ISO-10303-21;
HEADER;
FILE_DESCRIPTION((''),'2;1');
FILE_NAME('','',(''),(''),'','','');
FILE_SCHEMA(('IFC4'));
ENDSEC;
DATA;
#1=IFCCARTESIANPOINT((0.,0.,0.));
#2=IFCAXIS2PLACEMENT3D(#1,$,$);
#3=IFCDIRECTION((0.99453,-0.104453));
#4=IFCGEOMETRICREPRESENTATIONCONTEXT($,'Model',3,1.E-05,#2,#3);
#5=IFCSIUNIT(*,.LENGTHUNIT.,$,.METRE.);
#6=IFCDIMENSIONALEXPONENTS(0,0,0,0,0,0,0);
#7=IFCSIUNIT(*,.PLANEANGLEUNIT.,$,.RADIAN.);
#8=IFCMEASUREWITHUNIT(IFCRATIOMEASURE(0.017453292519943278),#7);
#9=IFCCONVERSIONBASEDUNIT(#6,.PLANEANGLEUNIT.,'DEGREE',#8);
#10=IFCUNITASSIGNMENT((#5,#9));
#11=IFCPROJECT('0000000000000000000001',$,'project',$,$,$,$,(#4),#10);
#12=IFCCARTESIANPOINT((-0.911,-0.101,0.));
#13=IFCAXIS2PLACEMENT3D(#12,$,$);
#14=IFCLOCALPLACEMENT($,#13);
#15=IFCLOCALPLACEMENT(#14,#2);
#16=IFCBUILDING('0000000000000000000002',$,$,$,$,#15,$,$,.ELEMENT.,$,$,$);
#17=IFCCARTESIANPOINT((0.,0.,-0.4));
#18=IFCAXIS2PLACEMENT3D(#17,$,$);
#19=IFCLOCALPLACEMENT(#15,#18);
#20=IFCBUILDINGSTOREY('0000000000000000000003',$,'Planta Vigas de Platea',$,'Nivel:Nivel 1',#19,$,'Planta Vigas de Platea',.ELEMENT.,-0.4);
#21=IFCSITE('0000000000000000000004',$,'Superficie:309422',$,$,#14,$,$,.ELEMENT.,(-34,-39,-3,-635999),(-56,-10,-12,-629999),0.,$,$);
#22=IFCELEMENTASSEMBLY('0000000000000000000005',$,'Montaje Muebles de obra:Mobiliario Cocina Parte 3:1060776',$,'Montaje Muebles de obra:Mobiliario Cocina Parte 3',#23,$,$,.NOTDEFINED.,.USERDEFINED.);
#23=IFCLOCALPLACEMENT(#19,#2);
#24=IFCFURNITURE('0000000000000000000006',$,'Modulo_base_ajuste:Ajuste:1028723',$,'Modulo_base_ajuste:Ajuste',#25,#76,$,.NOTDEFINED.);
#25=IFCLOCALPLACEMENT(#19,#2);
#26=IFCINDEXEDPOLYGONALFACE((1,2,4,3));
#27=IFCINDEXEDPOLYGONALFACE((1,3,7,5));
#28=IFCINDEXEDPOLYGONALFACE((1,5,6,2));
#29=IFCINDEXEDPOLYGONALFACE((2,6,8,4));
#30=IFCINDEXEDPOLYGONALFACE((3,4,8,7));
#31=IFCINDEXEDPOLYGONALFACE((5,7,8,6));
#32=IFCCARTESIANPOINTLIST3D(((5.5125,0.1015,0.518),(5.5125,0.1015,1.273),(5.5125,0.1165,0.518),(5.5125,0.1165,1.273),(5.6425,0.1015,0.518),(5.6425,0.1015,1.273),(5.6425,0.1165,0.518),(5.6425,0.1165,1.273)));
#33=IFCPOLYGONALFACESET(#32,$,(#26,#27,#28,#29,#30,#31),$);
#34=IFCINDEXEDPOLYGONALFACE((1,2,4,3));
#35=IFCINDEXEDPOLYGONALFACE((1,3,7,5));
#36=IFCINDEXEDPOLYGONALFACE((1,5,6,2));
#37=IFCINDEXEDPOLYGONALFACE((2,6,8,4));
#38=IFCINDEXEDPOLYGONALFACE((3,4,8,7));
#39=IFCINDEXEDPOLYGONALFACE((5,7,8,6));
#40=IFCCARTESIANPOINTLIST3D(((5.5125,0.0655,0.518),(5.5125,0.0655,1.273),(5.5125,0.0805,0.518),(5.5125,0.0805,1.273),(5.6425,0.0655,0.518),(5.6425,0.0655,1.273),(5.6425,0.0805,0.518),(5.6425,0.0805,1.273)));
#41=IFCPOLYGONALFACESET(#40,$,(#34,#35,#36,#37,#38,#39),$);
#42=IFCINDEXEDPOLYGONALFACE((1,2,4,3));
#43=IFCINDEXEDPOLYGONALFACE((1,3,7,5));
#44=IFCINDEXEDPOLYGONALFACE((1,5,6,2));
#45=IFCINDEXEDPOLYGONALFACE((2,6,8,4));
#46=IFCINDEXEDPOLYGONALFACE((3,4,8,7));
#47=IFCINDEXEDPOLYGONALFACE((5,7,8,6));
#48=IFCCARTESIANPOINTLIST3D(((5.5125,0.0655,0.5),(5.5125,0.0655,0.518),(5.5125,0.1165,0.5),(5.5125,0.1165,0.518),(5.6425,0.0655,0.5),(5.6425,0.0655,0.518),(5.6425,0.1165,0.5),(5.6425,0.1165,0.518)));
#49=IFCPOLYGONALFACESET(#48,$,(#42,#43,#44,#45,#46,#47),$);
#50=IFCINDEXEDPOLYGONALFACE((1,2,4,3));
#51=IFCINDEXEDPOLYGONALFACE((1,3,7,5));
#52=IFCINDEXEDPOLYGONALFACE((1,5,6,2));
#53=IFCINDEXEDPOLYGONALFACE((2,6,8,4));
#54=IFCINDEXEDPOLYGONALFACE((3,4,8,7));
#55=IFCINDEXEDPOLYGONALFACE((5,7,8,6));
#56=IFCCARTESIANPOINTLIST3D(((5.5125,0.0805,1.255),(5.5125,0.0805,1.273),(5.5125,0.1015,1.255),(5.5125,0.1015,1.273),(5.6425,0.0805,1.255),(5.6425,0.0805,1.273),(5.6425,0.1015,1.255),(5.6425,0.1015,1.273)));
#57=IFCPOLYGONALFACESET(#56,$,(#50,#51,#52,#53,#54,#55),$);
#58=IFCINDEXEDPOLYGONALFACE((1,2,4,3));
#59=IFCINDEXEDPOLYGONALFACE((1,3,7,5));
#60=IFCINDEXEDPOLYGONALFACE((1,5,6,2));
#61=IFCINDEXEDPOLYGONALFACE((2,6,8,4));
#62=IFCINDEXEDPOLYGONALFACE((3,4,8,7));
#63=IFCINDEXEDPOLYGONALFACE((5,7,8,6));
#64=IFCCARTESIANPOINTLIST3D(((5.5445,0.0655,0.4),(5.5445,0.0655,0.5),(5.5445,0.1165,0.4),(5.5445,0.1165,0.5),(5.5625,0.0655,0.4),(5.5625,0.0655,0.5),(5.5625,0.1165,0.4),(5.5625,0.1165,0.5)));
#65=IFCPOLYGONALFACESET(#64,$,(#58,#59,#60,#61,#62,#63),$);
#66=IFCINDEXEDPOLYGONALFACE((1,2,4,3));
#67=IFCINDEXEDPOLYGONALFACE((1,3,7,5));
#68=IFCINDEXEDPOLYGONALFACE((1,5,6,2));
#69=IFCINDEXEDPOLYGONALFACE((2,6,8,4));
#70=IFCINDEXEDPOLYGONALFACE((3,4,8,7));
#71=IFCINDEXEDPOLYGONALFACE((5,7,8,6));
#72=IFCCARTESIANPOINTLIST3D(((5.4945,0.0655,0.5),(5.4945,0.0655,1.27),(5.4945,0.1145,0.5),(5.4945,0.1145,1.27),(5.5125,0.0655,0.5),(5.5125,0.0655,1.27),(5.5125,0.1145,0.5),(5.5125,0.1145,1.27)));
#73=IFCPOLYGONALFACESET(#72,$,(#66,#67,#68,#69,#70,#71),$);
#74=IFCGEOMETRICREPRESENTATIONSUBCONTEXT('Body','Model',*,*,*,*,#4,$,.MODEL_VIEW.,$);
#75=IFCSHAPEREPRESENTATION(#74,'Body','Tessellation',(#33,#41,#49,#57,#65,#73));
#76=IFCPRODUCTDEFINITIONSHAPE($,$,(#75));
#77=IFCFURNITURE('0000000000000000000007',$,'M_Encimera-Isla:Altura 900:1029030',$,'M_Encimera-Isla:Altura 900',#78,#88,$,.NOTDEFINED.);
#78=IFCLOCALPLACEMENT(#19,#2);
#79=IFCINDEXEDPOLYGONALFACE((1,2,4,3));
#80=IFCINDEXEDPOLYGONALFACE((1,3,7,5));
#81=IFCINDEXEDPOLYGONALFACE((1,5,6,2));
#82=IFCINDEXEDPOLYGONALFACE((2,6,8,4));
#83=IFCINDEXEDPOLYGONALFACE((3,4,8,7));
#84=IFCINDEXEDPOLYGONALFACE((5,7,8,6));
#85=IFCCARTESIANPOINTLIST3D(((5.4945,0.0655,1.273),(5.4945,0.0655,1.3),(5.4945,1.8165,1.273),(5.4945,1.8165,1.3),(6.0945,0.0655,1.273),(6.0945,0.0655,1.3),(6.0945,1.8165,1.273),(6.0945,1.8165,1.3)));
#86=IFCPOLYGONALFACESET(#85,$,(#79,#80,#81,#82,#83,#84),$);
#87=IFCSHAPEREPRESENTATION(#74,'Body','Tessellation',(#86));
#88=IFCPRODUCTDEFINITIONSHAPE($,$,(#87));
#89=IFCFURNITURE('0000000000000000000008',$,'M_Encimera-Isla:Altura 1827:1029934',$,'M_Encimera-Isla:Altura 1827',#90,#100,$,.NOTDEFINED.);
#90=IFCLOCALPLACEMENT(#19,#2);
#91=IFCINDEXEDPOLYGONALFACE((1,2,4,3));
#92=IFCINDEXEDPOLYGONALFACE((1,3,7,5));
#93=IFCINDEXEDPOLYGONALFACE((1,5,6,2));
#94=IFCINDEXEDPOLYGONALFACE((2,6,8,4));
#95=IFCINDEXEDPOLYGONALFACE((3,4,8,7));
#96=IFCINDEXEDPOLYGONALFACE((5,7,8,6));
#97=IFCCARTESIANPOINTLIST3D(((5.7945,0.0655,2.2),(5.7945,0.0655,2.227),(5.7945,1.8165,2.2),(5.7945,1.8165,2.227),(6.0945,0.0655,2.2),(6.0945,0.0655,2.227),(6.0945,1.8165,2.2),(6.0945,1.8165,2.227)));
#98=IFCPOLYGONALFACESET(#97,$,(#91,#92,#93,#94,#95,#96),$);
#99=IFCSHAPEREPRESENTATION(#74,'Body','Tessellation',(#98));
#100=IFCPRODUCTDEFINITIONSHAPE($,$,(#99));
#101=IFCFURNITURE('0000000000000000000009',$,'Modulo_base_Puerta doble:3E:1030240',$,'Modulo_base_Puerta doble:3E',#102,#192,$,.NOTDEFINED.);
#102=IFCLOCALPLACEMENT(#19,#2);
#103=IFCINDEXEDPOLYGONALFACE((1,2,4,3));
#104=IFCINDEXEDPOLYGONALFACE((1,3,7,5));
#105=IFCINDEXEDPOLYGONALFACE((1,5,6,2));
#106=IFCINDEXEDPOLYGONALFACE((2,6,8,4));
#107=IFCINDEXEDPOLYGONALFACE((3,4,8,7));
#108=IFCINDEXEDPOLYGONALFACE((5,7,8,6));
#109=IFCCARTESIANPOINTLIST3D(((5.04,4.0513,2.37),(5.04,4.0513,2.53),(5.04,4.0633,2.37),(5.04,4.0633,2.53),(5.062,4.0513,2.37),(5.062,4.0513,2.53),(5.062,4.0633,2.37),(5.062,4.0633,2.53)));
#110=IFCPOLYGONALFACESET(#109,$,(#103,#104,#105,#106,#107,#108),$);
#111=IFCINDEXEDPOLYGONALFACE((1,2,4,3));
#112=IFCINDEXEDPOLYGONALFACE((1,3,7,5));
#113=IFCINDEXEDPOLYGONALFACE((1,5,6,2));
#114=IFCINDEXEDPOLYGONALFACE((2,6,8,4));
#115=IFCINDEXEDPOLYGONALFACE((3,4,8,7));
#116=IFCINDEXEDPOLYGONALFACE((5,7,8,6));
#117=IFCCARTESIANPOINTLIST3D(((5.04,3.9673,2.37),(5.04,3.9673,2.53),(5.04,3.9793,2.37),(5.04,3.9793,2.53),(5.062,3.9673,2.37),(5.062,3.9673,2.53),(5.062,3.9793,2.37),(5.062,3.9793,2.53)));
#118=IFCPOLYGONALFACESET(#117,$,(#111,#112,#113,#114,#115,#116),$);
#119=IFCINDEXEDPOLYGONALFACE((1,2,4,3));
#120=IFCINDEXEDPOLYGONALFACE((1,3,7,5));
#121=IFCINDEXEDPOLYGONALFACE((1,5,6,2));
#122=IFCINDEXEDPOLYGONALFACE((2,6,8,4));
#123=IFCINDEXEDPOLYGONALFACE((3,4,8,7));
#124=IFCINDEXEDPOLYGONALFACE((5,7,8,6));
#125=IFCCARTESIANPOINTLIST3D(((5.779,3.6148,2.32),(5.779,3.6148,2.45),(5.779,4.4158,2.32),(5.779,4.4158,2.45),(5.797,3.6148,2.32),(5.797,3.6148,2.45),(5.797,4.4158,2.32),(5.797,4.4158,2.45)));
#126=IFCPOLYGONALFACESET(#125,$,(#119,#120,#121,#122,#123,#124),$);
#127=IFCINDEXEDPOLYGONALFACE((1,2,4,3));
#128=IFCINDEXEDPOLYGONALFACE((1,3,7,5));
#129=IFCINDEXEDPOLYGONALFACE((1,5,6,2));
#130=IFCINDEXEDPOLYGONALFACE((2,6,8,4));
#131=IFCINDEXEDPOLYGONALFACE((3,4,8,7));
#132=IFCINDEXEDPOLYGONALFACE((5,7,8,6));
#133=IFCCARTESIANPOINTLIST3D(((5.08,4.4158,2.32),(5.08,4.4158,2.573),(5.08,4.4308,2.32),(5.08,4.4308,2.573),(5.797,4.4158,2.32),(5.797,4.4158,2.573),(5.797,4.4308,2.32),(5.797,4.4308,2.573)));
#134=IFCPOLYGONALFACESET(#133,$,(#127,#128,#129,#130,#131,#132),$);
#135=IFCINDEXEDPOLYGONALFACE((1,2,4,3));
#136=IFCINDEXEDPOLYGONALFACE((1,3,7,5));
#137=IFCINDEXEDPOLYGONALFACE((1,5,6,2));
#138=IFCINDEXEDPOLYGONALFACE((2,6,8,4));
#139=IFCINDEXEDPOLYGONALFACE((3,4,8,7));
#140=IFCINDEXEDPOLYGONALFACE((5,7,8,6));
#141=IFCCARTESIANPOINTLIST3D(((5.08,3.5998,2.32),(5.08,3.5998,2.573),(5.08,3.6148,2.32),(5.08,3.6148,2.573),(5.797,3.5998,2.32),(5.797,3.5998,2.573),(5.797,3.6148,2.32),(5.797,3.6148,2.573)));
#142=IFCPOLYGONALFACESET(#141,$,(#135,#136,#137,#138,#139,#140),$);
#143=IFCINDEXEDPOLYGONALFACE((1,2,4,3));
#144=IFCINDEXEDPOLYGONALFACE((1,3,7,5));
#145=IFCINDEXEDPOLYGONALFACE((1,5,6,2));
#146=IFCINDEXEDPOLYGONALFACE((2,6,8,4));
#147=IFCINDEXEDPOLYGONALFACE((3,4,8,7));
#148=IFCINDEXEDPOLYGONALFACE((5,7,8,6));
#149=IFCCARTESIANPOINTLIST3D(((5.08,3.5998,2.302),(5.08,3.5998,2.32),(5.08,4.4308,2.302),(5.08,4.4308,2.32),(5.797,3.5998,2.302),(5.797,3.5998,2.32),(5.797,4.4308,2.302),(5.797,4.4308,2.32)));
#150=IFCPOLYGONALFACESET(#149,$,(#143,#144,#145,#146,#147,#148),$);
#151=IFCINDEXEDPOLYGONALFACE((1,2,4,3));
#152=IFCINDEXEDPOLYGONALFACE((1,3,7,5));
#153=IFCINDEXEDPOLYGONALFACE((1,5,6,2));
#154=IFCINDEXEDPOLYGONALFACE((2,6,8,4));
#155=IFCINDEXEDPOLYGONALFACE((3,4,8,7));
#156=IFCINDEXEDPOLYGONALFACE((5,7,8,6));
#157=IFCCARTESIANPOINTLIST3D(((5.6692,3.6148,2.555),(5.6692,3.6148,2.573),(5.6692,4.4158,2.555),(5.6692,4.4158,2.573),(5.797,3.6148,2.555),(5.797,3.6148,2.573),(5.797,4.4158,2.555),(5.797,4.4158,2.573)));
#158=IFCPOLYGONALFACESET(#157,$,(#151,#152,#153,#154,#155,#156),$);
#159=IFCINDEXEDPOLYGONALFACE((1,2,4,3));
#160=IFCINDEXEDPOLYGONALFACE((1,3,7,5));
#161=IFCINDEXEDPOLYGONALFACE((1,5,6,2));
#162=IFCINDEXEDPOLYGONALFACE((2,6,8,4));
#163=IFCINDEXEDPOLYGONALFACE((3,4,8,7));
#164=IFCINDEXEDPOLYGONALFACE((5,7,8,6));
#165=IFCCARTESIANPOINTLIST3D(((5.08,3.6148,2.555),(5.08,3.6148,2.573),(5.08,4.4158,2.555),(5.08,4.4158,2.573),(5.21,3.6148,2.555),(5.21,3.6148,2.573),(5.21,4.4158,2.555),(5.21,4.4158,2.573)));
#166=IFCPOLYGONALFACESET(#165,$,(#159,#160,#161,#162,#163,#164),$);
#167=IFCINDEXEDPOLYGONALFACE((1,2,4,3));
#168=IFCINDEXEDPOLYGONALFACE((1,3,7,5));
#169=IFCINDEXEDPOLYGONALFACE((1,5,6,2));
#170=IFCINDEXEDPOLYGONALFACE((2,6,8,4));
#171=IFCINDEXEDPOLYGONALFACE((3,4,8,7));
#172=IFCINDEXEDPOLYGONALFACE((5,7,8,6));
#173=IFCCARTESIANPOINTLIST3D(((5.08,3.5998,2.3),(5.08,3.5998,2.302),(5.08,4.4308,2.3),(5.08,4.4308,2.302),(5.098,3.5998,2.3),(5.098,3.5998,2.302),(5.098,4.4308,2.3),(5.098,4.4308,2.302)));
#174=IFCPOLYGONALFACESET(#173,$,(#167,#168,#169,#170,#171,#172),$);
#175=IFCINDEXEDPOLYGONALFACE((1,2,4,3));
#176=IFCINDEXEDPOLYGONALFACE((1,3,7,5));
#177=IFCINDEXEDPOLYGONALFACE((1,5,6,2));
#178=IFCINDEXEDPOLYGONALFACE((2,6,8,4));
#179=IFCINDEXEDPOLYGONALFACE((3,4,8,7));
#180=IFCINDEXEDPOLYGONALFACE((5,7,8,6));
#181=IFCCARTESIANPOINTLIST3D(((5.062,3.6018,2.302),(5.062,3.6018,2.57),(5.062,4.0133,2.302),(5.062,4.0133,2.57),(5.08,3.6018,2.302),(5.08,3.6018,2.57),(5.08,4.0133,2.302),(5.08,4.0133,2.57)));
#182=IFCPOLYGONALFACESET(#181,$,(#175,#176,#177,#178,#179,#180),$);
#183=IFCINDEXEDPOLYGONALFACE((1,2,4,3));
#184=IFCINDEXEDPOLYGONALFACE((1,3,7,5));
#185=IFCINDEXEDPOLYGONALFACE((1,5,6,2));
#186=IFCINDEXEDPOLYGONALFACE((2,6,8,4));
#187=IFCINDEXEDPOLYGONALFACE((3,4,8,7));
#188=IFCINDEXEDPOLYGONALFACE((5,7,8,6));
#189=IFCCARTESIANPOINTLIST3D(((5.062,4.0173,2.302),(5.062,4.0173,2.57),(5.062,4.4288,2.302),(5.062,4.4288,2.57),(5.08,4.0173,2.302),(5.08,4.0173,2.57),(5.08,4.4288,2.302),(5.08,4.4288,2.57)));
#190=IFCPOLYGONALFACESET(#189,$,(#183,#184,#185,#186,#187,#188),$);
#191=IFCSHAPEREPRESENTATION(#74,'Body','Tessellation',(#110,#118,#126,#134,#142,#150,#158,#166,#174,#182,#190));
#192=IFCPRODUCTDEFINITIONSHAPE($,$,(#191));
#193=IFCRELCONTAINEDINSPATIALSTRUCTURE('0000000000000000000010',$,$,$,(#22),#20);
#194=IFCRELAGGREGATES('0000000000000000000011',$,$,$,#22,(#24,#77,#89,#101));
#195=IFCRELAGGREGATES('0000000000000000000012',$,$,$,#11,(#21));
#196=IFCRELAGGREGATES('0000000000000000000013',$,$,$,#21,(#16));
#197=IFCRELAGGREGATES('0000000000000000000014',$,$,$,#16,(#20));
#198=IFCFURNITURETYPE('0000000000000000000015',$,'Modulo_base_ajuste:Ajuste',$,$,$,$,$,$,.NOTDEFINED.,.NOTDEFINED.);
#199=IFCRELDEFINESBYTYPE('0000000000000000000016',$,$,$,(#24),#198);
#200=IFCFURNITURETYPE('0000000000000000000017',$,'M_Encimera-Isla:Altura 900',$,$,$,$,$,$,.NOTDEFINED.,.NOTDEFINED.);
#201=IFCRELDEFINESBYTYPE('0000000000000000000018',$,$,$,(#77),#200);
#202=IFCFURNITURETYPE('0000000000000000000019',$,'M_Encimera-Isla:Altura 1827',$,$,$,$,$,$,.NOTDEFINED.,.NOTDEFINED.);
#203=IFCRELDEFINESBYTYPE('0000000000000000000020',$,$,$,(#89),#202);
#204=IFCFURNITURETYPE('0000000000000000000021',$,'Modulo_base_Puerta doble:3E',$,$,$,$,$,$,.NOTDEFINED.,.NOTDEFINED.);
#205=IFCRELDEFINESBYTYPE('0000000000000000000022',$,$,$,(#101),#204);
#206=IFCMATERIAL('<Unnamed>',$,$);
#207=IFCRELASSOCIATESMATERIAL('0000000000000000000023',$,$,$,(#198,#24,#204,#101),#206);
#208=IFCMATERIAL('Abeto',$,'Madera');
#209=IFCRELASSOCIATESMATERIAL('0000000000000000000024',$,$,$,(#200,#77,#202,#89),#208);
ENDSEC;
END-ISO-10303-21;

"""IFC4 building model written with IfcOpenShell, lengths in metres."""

from ifc_helpers import new_model, entity, si_unit, converted_unit, direction, frame, frame_2d, origin, origin_2d_with_axis, place, context, subcontext, project, spatial, rectangle, extrude, source, transform, mapped, material, type_object, type_shapes, element, aggregate, save


model = new_model("IFC4")

# Units and contexts
model_context = context("Model", 3, precision=1e-05, world=origin(), true_north=direction((0.99453, -0.104453)))
body_context = subcontext(model_context, "Body", "Model", "MODEL_VIEW")
ifc_project = project(units=[si_unit("LENGTHUNIT", "METRE"), converted_unit("PLANEANGLEUNIT", "DEGREE", entity("IfcRatioMeasure", 0.017453292519943278), si_unit("PLANEANGLEUNIT", "RADIAN"), dimensions=[0, 0, 0, 0, 0, 0, 0])], contexts=[model_context])

# Site, building, storey
site_placement = place(None, frame((-0.911, -0.101, 0.0)))
site = spatial("IfcSite", under=ifc_project, at=site_placement, Name="Superficie:309422", CompositionType="ELEMENT", RefLatitude=(-34, -39, -3, -635999), RefLongitude=(-56, -10, -12, -629999), RefElevation=0.0)
building_placement = place(site_placement, origin())
building = spatial("IfcBuilding", under=site, at=building_placement, CompositionType="ELEMENT")
storey_placement = place(building_placement, frame((0.0, 0.0, -0.4)))
storey = spatial("IfcBuildingStorey", under=building, at=storey_placement, Name="Planta Vigas de Platea", ObjectType="Nivel:Nivel 1", LongName="Planta Vigas de Platea", CompositionType="ELEMENT", Elevation=-0.4)

# Element assembly, furniture
ifc_material_1 = material(Name="Abeto", Category="Madera")
ifc_material_2 = material(Name="<Unnamed>")
assembly_1_placement = place(storey_placement, origin())
assembly_1 = element("IfcElementAssembly", 1, at=assembly_1_placement, inside=storey, Name="Montaje Muebles de obra:Mobiliario Cocina Parte 3:1060776", ObjectType="Montaje Muebles de obra:Mobiliario Cocina Parte 3", AssemblyPlace="NOTDEFINED", PredefinedType="USERDEFINED")
furniture_type_1 = type_object("IfcFurnitureType", Name="Modulo_base_ajuste:Ajuste", AssemblyPlace="NOTDEFINED", PredefinedType="NOTDEFINED", material=ifc_material_2)
shared_shape_1 = source(origin(), body_context, "Body", "SweptSolid", [
    extrude(rectangle(XDim=0.015, YDim=0.13, at=frame_2d((0.0, 0.0), x_axis=(1.0, 0.0))), frame((0.083, 0.0435, 0.118), z_axis=(0.0, 0.0, 1.0), x_axis=(0.0, 1.0, 0.0)), (0.0, 0.0, 1.0), 0.755),
    extrude(rectangle(XDim=0.015, YDim=0.13, at=frame_2d((0.0, 0.0), x_axis=(1.0, 0.0))), frame((0.083, 0.0075, 0.118), z_axis=(0.0, 0.0, 1.0), x_axis=(0.0, -1.0, 0.0)), (0.0, 0.0, 1.0), 0.755),
    extrude(rectangle(XDim=0.051, YDim=0.13, at=origin_2d_with_axis()), frame((0.083, 0.0255, 0.1), z_axis=(0.0, 0.0, 1.0), x_axis=(0.0, 1.0, 0.0)), (0.0, 0.0, 1.0), 0.018),
    extrude(rectangle(XDim=0.021, YDim=0.13, at=frame_2d((0.0, 0.0), x_axis=(1.0, 0.0))), frame((0.083, 0.0255, 0.855), z_axis=(0.0, 0.0, 1.0), x_axis=(0.0, 1.0, 0.0)), (0.0, 0.0, 1.0), 0.018),
    extrude(rectangle(XDim=0.018, YDim=0.051, at=frame_2d((0.0, 0.0), x_axis=(1.0, 0.0))), frame((0.059, 0.0255, 0.0), z_axis=(0.0, 0.0, 1.0), x_axis=(-1.0, 0.0, 0.0)), (0.0, 0.0, 1.0), 0.1),
    extrude(rectangle(XDim=0.018, YDim=0.049, at=frame_2d((0.0, 0.0), x_axis=(1.0, 0.0))), frame((0.009, 0.0245, 0.1)), (0.0, 0.0, 1.0), 0.77),
])
type_shapes(furniture_type_1, [shared_shape_1])
furniture_1_placement = place(assembly_1_placement, frame((5.4945, 0.0655, 0.4)))
furniture_1 = element("IfcFurniture", 2, at=furniture_1_placement, type_object=furniture_type_1, material=ifc_material_2, Name="Modulo_base_ajuste:Ajuste:1028723", ObjectType="Modulo_base_ajuste:Ajuste", PredefinedType="NOTDEFINED", context=body_context, shape_type="MappedRepresentation", body=[
    mapped(shared_shape_1, transform((0.0, 0.0, 0.0), scale=1.0)),
])
furniture_type_2 = type_object("IfcFurnitureType", Name="M_Encimera-Isla:Altura 900", AssemblyPlace="NOTDEFINED", PredefinedType="NOTDEFINED", material=ifc_material_1)
shared_shape_2 = source(origin(), body_context, "Body", "SweptSolid", [
    extrude(rectangle(XDim=1.751, YDim=0.6, at=frame_2d((0.0, 0.0), x_axis=(1.0, 0.0))), frame((0.8755, 0.3, 0.0), z_axis=(0.0, 0.0, 1.0), x_axis=(-1.0, 0.0, 0.0)), (0.0, 0.0, 1.0), 0.027),
])
type_shapes(furniture_type_2, [shared_shape_2])
furniture_2_placement = place(assembly_1_placement, frame((5.4945, 1.8165, 1.273), z_axis=(0.0, 0.0, 1.0), x_axis=(0.0, -1.0, 0.0)))
furniture_2 = element("IfcFurniture", 3, at=furniture_2_placement, type_object=furniture_type_2, material=ifc_material_1, Name="M_Encimera-Isla:Altura 900:1029030", ObjectType="M_Encimera-Isla:Altura 900", PredefinedType="NOTDEFINED", context=body_context, shape_type="MappedRepresentation", body=[
    mapped(shared_shape_2, transform((0.0, 0.0, 0.0), scale=1.0)),
])
furniture_type_3 = type_object("IfcFurnitureType", Name="M_Encimera-Isla:Altura 1827", AssemblyPlace="NOTDEFINED", PredefinedType="NOTDEFINED", material=ifc_material_1)
shared_shape_3 = source(origin(), body_context, "Body", "SweptSolid", [
    extrude(rectangle(XDim=1.751, YDim=0.3, at=origin_2d_with_axis()), frame((0.8755, 0.15, 0.0), z_axis=(0.0, 0.0, 1.0), x_axis=(-1.0, 0.0, 0.0)), (0.0, 0.0, 1.0), 0.027),
])
type_shapes(furniture_type_3, [shared_shape_3])
furniture_3_placement = place(assembly_1_placement, frame((6.0945, 0.0655, 2.2), z_axis=(0.0, 0.0, 1.0), x_axis=(0.0, 1.0, 0.0)))
furniture_3 = element("IfcFurniture", 4, at=furniture_3_placement, type_object=furniture_type_3, material=ifc_material_1, Name="M_Encimera-Isla:Altura 1827:1029934", ObjectType="M_Encimera-Isla:Altura 1827", PredefinedType="NOTDEFINED", context=body_context, shape_type="MappedRepresentation", body=[
    mapped(shared_shape_3, transform((0.0, 0.0, 0.0), scale=1.0)),
])
furniture_type_4 = type_object("IfcFurnitureType", Name="Modulo_base_Puerta doble:3E", AssemblyPlace="NOTDEFINED", PredefinedType="NOTDEFINED", material=ifc_material_2)
shared_shape_4 = source(origin(), body_context, "Body", "SweptSolid", [
    extrude(rectangle(XDim=0.022, YDim=0.012, at=frame_2d((0.0, 0.0), x_axis=(1.0, 0.0))), frame((0.011, 0.4575, 0.07)), (0.0, 0.0, 1.0), 0.16),
    extrude(rectangle(XDim=0.022, YDim=0.012, at=frame_2d((0.0, 0.0), x_axis=(1.0, 0.0))), frame((0.011, 0.3735, 0.07)), (0.0, 0.0, 1.0), 0.16),
    extrude(rectangle(XDim=0.801, YDim=0.018, at=frame_2d((0.0, 0.0), x_axis=(1.0, 0.0))), frame((0.748, 0.4155, 0.02), z_axis=(0.0, 0.0, 1.0), x_axis=(0.0, 1.0, 0.0)), (0.0, 0.0, 1.0), 0.13),
    extrude(rectangle(XDim=0.015, YDim=0.717, at=frame_2d((-0.0015, -0.0457), x_axis=(1.0, 0.0))), frame((0.3528, 0.825, 0.02), z_axis=(0.0, 0.0, 1.0), x_axis=(0.0, 1.0, 0.0)), (0.0, 0.0, 1.0), 0.253),
    extrude(rectangle(XDim=0.015, YDim=0.717, at=frame_2d((-0.0015, 0.0457), x_axis=(1.0, 0.0))), frame((0.3528, 0.006, 0.02), z_axis=(0.0, 0.0, 1.0), x_axis=(0.0, -1.0, 0.0)), (0.0, 0.0, 1.0), 0.253),
    extrude(rectangle(XDim=0.831, YDim=0.717, at=frame_2d((0.0, -0.0762), x_axis=(1.0, 0.0))), frame((0.3223, 0.4155, 0.002), z_axis=(0.0, 0.0, 1.0), x_axis=(0.0, 1.0, 0.0)), (0.0, 0.0, 1.0), 0.018),
    extrude(rectangle(XDim=0.801, YDim=0.1278, at=frame_2d((0.0, 0.0), x_axis=(1.0, 0.0))), frame((0.6931, 0.4155, 0.255), z_axis=(0.0, 0.0, 1.0), x_axis=(0.0, 1.0, 0.0)), (0.0, 0.0, 1.0), 0.018),
    extrude(rectangle(XDim=0.801, YDim=0.13, at=frame_2d((0.0, 0.0), x_axis=(1.0, 0.0))), frame((0.105, 0.4155, 0.255), z_axis=(0.0, 0.0, 1.0), x_axis=(0.0, 1.0, 0.0)), (0.0, 0.0, 1.0), 0.018),
    extrude(rectangle(XDim=0.018, YDim=0.831, at=frame_2d((0.0, 0.0), x_axis=(1.0, 0.0))), frame((0.049, 0.4155, 0.0), z_axis=(0.0, 0.0, 1.0), x_axis=(-1.0, 0.0, 0.0)), (0.0, 0.0, 1.0), 0.002),
    extrude(rectangle(XDim=0.018, YDim=0.4115, at=frame_2d((0.0, 0.0), x_axis=(1.0, 0.0))), frame((0.031, 0.2077, 0.002)), (0.0, 0.0, 1.0), 0.268),
    extrude(rectangle(XDim=0.018, YDim=0.4115, at=frame_2d((0.0, 0.0), x_axis=(1.0, 0.0))), frame((0.031, 0.6232, 0.002)), (0.0, 0.0, 1.0), 0.268),
])
type_shapes(furniture_type_4, [shared_shape_4])
furniture_4_placement = place(assembly_1_placement, frame((5.04, 3.5998, 2.3)))
furniture_4 = element("IfcFurniture", 5, at=furniture_4_placement, type_object=furniture_type_4, material=ifc_material_2, Name="Modulo_base_Puerta doble:3E:1030240", ObjectType="Modulo_base_Puerta doble:3E", PredefinedType="NOTDEFINED", context=body_context, shape_type="MappedRepresentation", body=[
    mapped(shared_shape_4, transform((0.0, 0.0, 0.0), scale=1.0)),
])

aggregate(assembly_1, [furniture_1, furniture_2, furniture_3, furniture_4])

save(model, "model.ifc")
